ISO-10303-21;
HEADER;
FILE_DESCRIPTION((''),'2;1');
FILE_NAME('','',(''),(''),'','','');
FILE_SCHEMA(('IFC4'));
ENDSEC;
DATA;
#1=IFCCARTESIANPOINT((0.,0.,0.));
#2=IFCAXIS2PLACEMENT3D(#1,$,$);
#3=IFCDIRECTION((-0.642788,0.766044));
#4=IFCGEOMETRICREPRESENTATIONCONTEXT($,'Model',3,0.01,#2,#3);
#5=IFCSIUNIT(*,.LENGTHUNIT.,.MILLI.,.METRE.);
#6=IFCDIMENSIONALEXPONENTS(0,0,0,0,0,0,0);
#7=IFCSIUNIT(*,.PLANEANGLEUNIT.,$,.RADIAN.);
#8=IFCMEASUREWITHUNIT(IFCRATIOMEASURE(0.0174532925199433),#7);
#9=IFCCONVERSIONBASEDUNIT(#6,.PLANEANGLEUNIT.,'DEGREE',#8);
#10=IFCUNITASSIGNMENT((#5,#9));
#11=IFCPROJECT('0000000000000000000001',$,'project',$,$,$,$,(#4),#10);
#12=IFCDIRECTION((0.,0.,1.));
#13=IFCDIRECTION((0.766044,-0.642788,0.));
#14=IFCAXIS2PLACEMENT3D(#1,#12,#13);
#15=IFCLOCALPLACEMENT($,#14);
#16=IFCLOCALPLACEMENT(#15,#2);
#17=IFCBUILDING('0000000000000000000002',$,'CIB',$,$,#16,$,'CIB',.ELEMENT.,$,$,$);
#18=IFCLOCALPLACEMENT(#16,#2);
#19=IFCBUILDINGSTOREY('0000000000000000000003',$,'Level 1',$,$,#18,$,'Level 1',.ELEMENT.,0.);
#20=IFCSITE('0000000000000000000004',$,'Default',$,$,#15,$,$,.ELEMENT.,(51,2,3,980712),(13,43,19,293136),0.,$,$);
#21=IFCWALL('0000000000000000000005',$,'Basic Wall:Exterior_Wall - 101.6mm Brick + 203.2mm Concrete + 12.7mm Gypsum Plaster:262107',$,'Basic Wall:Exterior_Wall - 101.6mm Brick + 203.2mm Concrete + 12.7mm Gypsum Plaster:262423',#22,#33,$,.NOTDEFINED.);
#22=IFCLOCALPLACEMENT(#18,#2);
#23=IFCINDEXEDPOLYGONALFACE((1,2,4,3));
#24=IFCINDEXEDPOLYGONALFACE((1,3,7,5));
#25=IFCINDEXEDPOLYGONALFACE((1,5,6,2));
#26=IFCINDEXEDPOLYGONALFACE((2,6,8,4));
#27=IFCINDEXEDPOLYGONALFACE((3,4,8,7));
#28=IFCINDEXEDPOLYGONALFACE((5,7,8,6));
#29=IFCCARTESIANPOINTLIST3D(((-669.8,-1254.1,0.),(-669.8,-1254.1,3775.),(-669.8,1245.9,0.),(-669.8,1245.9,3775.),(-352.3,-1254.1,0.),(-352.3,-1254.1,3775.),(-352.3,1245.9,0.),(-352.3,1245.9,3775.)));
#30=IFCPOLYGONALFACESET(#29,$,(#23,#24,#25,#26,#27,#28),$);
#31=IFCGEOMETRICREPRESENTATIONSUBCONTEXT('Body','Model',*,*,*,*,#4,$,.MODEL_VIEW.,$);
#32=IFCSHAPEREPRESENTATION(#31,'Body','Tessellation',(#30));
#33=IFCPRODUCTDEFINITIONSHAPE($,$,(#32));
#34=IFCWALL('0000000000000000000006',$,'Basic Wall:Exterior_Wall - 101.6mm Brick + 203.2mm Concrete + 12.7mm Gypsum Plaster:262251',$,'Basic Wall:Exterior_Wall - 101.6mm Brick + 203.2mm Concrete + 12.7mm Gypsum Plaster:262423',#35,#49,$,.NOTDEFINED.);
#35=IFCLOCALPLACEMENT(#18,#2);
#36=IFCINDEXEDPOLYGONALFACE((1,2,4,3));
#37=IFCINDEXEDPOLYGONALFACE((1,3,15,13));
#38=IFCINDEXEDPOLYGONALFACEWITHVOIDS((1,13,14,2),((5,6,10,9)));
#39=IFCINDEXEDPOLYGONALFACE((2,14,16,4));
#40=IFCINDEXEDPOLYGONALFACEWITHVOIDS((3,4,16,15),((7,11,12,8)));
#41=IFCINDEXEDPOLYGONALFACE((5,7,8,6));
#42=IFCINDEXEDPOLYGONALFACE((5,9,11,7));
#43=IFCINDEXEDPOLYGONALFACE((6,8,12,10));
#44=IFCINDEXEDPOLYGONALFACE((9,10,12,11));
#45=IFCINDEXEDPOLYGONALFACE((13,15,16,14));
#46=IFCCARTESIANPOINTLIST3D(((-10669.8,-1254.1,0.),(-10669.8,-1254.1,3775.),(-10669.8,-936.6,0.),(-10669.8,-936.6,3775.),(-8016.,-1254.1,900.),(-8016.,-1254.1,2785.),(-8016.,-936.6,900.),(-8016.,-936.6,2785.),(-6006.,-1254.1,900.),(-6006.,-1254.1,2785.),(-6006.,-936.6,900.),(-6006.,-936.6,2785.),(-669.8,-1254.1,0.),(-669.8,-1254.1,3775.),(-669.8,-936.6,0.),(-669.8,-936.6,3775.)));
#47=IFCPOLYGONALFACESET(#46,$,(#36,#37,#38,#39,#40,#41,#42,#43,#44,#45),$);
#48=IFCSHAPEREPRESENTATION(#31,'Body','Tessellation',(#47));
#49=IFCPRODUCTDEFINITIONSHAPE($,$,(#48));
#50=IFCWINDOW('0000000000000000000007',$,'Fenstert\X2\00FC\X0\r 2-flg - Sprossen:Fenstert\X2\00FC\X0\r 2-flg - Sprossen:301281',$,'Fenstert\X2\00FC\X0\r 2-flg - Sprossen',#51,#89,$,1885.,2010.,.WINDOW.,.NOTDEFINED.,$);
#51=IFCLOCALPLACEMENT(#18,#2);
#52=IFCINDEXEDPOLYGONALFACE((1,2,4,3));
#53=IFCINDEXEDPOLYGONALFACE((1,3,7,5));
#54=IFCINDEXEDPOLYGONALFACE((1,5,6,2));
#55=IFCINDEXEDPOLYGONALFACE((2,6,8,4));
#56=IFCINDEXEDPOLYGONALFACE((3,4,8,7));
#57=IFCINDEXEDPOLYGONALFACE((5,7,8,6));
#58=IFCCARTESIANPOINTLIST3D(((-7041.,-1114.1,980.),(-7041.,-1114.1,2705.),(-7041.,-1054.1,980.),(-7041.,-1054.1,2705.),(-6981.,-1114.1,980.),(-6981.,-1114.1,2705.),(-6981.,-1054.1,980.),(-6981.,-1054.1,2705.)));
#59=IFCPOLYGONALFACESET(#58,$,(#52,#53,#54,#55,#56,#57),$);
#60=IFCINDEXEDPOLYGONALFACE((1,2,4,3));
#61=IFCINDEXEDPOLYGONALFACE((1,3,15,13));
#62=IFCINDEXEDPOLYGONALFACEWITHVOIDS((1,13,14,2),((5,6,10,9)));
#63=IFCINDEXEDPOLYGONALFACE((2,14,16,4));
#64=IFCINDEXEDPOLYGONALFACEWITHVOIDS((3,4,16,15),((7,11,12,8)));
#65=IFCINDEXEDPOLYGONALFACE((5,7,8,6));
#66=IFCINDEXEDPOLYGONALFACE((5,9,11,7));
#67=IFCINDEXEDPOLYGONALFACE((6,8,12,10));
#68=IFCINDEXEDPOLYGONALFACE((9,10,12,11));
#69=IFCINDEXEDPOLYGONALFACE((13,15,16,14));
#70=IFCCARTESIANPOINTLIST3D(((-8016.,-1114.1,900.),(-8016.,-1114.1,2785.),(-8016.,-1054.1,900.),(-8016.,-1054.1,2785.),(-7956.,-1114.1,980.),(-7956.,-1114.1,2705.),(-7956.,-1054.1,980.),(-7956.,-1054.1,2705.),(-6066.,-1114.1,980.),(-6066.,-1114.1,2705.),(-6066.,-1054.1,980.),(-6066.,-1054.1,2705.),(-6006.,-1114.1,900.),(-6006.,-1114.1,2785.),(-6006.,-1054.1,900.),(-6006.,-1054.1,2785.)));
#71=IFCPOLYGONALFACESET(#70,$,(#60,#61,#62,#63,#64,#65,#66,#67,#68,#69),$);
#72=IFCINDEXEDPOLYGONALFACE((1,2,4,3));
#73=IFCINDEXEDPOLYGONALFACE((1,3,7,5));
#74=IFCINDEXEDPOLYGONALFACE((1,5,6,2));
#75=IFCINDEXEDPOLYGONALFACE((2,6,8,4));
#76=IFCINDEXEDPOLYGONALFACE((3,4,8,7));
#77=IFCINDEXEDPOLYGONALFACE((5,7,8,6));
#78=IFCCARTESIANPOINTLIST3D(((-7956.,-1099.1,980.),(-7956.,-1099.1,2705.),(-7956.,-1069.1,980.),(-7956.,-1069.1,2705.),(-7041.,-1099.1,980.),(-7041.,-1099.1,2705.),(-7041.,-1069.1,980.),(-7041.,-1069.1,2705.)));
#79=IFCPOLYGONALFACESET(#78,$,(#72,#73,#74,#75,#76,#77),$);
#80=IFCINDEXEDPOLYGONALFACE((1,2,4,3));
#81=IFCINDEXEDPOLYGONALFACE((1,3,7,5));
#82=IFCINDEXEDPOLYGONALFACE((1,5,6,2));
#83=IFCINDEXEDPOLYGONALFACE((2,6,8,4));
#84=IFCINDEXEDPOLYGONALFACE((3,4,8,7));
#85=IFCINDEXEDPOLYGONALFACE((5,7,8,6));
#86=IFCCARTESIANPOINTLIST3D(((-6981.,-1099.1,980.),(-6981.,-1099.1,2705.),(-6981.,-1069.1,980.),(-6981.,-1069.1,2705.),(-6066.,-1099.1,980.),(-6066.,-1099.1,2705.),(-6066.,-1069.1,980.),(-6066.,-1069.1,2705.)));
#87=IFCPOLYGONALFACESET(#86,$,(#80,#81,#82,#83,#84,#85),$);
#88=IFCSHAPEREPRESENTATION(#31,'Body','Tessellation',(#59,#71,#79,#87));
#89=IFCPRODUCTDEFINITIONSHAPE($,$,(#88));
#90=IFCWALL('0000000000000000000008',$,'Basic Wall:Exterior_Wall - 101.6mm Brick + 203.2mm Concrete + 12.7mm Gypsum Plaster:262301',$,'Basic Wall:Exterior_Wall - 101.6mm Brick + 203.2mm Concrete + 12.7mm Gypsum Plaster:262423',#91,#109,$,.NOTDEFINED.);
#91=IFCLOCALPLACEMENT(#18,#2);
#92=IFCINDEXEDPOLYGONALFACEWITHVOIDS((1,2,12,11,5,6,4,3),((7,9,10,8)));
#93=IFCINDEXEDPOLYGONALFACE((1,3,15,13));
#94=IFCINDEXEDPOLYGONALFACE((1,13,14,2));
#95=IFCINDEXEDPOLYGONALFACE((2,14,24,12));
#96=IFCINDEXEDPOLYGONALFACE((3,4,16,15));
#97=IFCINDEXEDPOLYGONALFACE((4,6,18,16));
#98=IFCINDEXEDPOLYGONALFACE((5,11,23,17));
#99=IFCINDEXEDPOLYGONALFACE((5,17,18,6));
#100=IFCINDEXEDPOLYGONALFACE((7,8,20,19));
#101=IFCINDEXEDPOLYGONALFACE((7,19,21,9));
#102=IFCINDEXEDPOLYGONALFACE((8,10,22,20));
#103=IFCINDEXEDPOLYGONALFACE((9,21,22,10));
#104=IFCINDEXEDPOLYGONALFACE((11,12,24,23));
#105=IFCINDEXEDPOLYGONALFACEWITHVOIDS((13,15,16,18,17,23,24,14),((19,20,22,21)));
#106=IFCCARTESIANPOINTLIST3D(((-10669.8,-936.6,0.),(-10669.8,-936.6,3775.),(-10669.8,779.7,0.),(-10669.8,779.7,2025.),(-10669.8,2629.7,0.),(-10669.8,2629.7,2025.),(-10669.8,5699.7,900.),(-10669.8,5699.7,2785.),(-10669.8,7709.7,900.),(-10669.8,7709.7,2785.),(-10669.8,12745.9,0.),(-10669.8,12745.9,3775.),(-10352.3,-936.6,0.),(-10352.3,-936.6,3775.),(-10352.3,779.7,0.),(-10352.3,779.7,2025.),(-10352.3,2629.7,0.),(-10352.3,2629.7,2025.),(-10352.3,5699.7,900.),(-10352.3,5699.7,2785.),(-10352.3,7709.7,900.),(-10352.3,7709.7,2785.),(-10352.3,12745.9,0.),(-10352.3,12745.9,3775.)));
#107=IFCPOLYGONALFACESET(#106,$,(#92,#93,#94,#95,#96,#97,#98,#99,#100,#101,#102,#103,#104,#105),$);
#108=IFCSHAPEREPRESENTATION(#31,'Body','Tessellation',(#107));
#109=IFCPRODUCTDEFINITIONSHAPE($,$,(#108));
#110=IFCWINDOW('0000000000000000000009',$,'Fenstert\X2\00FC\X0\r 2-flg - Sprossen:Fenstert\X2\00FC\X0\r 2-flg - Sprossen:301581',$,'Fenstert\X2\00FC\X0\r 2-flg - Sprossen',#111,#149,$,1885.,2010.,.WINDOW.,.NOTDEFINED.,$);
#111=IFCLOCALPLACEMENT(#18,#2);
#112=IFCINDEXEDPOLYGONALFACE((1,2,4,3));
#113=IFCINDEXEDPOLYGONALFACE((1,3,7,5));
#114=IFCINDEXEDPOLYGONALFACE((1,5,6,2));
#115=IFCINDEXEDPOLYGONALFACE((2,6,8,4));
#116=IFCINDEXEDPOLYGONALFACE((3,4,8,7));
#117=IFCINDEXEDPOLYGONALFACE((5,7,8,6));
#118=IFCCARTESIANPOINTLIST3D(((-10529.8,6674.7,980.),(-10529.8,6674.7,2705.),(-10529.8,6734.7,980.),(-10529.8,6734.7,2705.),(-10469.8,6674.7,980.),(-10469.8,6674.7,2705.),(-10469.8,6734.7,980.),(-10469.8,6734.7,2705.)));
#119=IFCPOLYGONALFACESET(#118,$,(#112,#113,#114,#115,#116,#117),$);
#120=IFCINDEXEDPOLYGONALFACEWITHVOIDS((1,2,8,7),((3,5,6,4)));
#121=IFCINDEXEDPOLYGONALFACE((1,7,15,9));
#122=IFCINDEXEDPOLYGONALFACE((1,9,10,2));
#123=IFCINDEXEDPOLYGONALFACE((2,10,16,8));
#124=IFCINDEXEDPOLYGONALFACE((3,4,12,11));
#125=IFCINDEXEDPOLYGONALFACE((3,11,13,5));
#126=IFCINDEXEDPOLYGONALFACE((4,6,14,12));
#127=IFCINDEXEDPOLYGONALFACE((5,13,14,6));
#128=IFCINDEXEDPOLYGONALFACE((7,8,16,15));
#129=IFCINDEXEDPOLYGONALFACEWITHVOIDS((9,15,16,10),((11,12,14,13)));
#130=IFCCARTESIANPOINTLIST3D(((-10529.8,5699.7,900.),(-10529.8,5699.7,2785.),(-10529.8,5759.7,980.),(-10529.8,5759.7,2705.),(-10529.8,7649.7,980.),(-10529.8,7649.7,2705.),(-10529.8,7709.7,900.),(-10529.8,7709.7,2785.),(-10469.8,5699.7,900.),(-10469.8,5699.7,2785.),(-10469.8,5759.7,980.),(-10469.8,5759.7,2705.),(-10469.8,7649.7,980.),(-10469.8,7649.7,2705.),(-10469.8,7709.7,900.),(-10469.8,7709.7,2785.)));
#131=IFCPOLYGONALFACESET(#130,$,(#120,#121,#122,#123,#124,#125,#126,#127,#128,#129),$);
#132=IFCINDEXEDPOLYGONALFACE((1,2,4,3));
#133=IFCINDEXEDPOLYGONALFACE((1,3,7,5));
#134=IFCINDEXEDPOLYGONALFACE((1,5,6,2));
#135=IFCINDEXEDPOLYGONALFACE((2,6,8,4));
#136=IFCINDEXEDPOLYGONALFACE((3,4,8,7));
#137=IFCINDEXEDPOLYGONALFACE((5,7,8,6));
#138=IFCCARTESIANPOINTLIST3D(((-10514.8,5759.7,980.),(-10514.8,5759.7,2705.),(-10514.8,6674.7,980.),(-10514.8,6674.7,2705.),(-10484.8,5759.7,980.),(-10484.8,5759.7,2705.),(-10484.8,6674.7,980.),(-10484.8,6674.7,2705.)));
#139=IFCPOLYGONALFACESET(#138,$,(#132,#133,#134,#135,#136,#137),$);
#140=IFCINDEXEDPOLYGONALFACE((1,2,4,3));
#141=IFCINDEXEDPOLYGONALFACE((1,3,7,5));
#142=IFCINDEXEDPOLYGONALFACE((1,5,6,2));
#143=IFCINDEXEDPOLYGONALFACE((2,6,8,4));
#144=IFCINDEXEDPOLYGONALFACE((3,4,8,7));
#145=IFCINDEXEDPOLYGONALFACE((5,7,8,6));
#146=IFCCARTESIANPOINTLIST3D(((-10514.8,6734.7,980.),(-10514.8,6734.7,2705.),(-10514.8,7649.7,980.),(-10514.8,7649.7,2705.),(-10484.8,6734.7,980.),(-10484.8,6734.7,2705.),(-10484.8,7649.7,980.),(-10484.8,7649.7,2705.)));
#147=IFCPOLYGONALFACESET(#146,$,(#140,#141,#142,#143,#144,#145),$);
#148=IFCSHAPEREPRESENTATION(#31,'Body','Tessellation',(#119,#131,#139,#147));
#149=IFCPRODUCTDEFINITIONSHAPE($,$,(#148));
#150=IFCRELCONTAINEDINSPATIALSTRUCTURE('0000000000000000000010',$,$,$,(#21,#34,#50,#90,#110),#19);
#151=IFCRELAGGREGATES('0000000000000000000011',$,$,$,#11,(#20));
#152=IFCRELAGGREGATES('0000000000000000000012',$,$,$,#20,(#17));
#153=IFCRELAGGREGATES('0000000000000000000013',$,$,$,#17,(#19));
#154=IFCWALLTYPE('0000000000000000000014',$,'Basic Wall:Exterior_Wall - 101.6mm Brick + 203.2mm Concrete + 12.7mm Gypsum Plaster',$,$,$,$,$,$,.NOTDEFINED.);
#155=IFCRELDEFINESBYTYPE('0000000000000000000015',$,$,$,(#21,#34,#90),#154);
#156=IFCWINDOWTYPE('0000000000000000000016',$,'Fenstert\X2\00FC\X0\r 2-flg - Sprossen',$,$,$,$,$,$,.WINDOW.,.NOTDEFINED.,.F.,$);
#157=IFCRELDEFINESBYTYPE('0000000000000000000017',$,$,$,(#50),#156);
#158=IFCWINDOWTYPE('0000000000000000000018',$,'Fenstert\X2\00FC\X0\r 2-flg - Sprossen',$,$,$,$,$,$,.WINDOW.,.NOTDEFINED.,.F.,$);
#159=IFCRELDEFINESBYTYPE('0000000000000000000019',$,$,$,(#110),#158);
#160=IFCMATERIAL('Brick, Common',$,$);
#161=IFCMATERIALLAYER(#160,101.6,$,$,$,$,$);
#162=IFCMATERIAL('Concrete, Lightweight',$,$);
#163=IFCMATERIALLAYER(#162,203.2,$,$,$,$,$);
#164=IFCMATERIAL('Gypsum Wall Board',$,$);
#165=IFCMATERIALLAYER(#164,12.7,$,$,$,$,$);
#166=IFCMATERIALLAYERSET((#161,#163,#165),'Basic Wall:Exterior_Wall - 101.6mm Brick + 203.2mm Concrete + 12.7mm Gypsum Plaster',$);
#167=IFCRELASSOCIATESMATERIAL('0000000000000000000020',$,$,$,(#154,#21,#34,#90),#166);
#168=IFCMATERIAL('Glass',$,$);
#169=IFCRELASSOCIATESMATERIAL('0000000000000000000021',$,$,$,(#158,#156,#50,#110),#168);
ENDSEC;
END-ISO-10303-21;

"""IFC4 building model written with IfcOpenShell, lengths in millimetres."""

from ifc_helpers import new_model, entity, si_unit, converted_unit, direction, frame, frame_2d, origin, origin_2d_with_axis, place, context, subcontext, project, spatial, polyline, rectangle, outline, extrude, clip, bounded_halfspace, source, transform, mapped, material, layer, layer_set, layer_usage, type_object, type_shapes, element, fill, save


model = new_model("IFC4")

# Units and contexts
model_context = context("Model", 3, precision=0.01, world=origin(), true_north=direction((-0.642788, 0.766044)))
body_context = subcontext(model_context, "Body", "Model", "MODEL_VIEW")
ifc_project = project(units=[si_unit("LENGTHUNIT", "METRE", prefix="MILLI"), converted_unit("PLANEANGLEUNIT", "DEGREE", entity("IfcRatioMeasure", 0.0174532925199433), si_unit("PLANEANGLEUNIT", "RADIAN"), dimensions=[0, 0, 0, 0, 0, 0, 0])], contexts=[model_context])

# Site, building, storey
site_placement = place(None, frame((0.0, 0.0, 0.0), z_axis=(0.0, 0.0, 1.0), x_axis=(0.766044, -0.642788, 0.0)))
site = spatial("IfcSite", under=ifc_project, at=site_placement, Name="Default", CompositionType="ELEMENT", RefLatitude=(51, 2, 3, 980712), RefLongitude=(13, 43, 19, 293136), RefElevation=0.0)
building_placement = place(site_placement, origin())
building = spatial("IfcBuilding", under=site, at=building_placement, Name="CIB", LongName="CIB", CompositionType="ELEMENT")
storey_placement = place(building_placement, origin())
storey = spatial("IfcBuildingStorey", under=building, at=storey_placement, Name="Level 1", LongName="Level 1", CompositionType="ELEMENT", Elevation=0.0)

# Shared definitions
ifc_material_1 = material(Name="Brick, Common")
ifc_layer_1 = layer(ifc_material_1, 101.6)
ifc_material_2 = material(Name="Concrete, Lightweight")
ifc_layer_2 = layer(ifc_material_2, 203.2)
ifc_material_3 = material(Name="Gypsum Wall Board")
ifc_layer_3 = layer(ifc_material_3, 12.7)
ifc_layer_set_1 = layer_set([ifc_layer_1, ifc_layer_2, ifc_layer_3], Name="Basic Wall:Exterior_Wall - 101.6mm Brick + 203.2mm Concrete + 12.7mm Gypsum Plaster")
wall_type_1 = type_object("IfcWallType", Name="Basic Wall:Exterior_Wall - 101.6mm Brick + 203.2mm Concrete + 12.7mm Gypsum Plaster", PredefinedType="NOTDEFINED", material=ifc_layer_set_1)
ifc_material_4 = material(Name="Glass")
window_type_1 = type_object("IfcWindowType", Name="Fenstertür 2-flg - Sprossen", ParameterTakesPrecedence=False, PartitioningType="NOTDEFINED", PredefinedType="WINDOW", material=ifc_material_4)
shared_shape_1 = source(origin(), body_context, "Body", "SweptSolid", [
    extrude(rectangle(XDim=60.0, YDim=60.0, at=origin_2d_with_axis()), frame((1005.0, 147.5, 80.0), z_axis=(0.0, 0.0, 1.0), x_axis=(0.0, 1.0, 0.0)), (0.0, 0.0, 1.0), 1725.0),
    extrude(outline(polyline([(-1005.0, -942.5), (1005.0, -942.5), (1005.0, 942.5), (-1005.0, 942.5), (-1005.0, -942.5)]), holes=[polyline([(-945.0, -862.5), (-945.0, 862.5), (945.0, 862.5), (945.0, -862.5), (-945.0, -862.5)])]), frame((1005.0, 117.5, 942.5), z_axis=(0.0, 1.0, 0.0), x_axis=(1.0, 0.0, 0.0)), (0.0, 0.0, 1.0), 60.0),
    extrude(rectangle(XDim=30.0, YDim=915.0, at=frame_2d((0.0, 0.0), x_axis=(1.0, 0.0))), frame((517.5, 147.5, 80.0), z_axis=(0.0, 0.0, 1.0), x_axis=(0.0, -1.0, 0.0)), (0.0, 0.0, 1.0), 1725.0),
    extrude(rectangle(XDim=30.0, YDim=915.0, at=frame_2d((0.0, 0.0), x_axis=(1.0, 0.0))), frame((1492.5, 147.5, 80.0), z_axis=(0.0, 0.0, 1.0), x_axis=(0.0, -1.0, 0.0)), (0.0, 0.0, 1.0), 1725.0),
])
type_shapes(window_type_1, [shared_shape_1])

# Wall
ifc_layer_usage_1 = layer_usage(ifc_layer_set_1, "AXIS2", "NEGATIVE", 158.8)
wall_1_placement = place(storey_placement, frame((-511.0, 1245.9, 0.0), z_axis=(0.0, 0.0, 1.0), x_axis=(0.0, -1.0, 0.0)))
element("IfcWall", 1, at=wall_1_placement, inside=storey, type_object=wall_type_1, material=ifc_layer_usage_1, Name="Basic Wall:Exterior_Wall - 101.6mm Brick + 203.2mm Concrete + 12.7mm Gypsum Plaster:262107", ObjectType="Basic Wall:Exterior_Wall - 101.6mm Brick + 203.2mm Concrete + 12.7mm Gypsum Plaster:262423", PredefinedType="NOTDEFINED", context=body_context, shape_type="Clipping", body=[
    clip(extrude(rectangle(XDim=2500.0, YDim=317.5, at=frame_2d((1250.0, 0.0), x_axis=(-1.0, 0.0))), origin(), (0.0, 0.0, 1.0), 3775.0), bounded_halfspace(frame((0.0, -158.8, 3775.0), z_axis=(0.0, 0.0, -1.0), x_axis=(0.0, 1.0, 0.0)), True, frame((0.0, -158.8, 3775.0)), polyline([(0.0, 0.0), (2182.5, 0.0), (2500.0, 0.0), (2500.0, 317.5), (0.0, 317.5), (0.0, 0.0)]))),
])

# Wall, opening, window
ifc_layer_usage_2 = layer_usage(ifc_layer_set_1, "AXIS2", "NEGATIVE", 158.8)
wall_2_placement = place(storey_placement, frame((-669.8, -1095.3, 0.0), z_axis=(0.0, 0.0, 1.0), x_axis=(-1.0, 0.0, 0.0)))
wall_2 = element("IfcWall", 2, at=wall_2_placement, inside=storey, type_object=wall_type_1, material=ifc_layer_usage_2, Name="Basic Wall:Exterior_Wall - 101.6mm Brick + 203.2mm Concrete + 12.7mm Gypsum Plaster:262251", ObjectType="Basic Wall:Exterior_Wall - 101.6mm Brick + 203.2mm Concrete + 12.7mm Gypsum Plaster:262423", PredefinedType="NOTDEFINED", context=body_context, shape_type="Clipping", body=[
    clip(extrude(rectangle(XDim=10000.0, YDim=317.5, at=frame_2d((5000.0, 0.0), x_axis=(-1.0, 0.0))), origin(), (0.0, 0.0, 1.0), 3775.0), bounded_halfspace(frame((0.0, -158.8, 3775.0), z_axis=(0.0, 0.0, -1.0), x_axis=(-1.0, 0.0, 0.0)), True, frame((0.0, -158.8, 3775.0)), polyline([(0.0, 0.0), (9682.5, 0.0), (10000.0, 0.0), (10000.0, 317.5), (0.0, 317.5), (0.0, 0.0)]))),
])
opening_1_placement = place(wall_2_placement, frame((7346.2, 158.7, 900.0)))
opening_1 = element("IfcOpeningElement", 3, at=opening_1_placement, cuts=wall_2, ObjectType="Opening", PredefinedType="OPENING", context=body_context, shape_type="SweptSolid", body=[
    extrude(rectangle(XDim=1885.0, YDim=2010.0, at=frame_2d((942.5, 1005.0), x_axis=(1.0, 0.0))), frame((0.0, 0.0, 0.0), z_axis=(0.0, -1.0, 0.0), x_axis=(0.0, 0.0, 1.0)), (0.0, 0.0, 1.0), 317.5),
])
window_type_2 = type_object("IfcWindowType", Name="Fenstertür 2-flg - Sprossen", ParameterTakesPrecedence=False, PartitioningType="NOTDEFINED", PredefinedType="WINDOW", material=ifc_material_4)
shared_shape_2 = source(origin(), body_context, "Body", "SweptSolid", [
    extrude(rectangle(XDim=60.0, YDim=60.0, at=frame_2d((0.0, 0.0), x_axis=(1.0, 0.0))), frame((1005.0, 147.5, 80.0)), (0.0, 0.0, 1.0), 1725.0),
    extrude(outline(polyline([(-1005.0, -942.5), (1005.0, -942.5), (1005.0, 942.5), (-1005.0, 942.5), (-1005.0, -942.5)]), holes=[polyline([(-945.0, -862.5), (-945.0, 862.5), (945.0, 862.5), (945.0, -862.5), (-945.0, -862.5)])]), frame((1005.0, 177.5, 942.5), z_axis=(0.0, -1.0, 0.0), x_axis=(-1.0, 0.0, 0.0)), (0.0, 0.0, 1.0), 60.0),
    extrude(rectangle(XDim=915.0, YDim=30.0, at=frame_2d((0.0, 0.0), x_axis=(1.0, 0.0))), frame((1492.5, 147.5, 80.0), z_axis=(0.0, 0.0, 1.0), x_axis=(-1.0, 0.0, 0.0)), (0.0, 0.0, 1.0), 1725.0),
    extrude(rectangle(XDim=915.0, YDim=30.0, at=frame_2d((0.0, 0.0), x_axis=(1.0, 0.0))), frame((517.5, 147.5, 80.0), z_axis=(0.0, 0.0, 1.0), x_axis=(-1.0, 0.0, 0.0)), (0.0, 0.0, 1.0), 1725.0),
])
type_shapes(window_type_2, [shared_shape_2])
window_1_placement = place(opening_1_placement, frame((-2010.0, -317.5, 0.0)))
window_1 = element("IfcWindow", 4, at=window_1_placement, inside=storey, type_object=window_type_2, material=ifc_material_4, Name="Fenstertür 2-flg - Sprossen:Fenstertür 2-flg - Sprossen:301281", ObjectType="Fenstertür 2-flg - Sprossen", OverallHeight=1885.0, OverallWidth=2010.0, PartitioningType="NOTDEFINED", PredefinedType="WINDOW", context=body_context, shape_type="MappedRepresentation", body=[
    mapped(shared_shape_2, transform((0.0, 0.0, 0.0), scale=1.0)),
])
fill(opening_1, window_1)

# Wall, openings, window
ifc_layer_usage_3 = layer_usage(ifc_layer_set_1, "AXIS2", "NEGATIVE", 158.8)
wall_3_placement = place(storey_placement, frame((-10511.0, -936.6, 0.0), z_axis=(0.0, 0.0, 1.0), x_axis=(0.0, 1.0, 0.0)))
wall_3 = element("IfcWall", 5, at=wall_3_placement, inside=storey, type_object=wall_type_1, material=ifc_layer_usage_3, Name="Basic Wall:Exterior_Wall - 101.6mm Brick + 203.2mm Concrete + 12.7mm Gypsum Plaster:262301", ObjectType="Basic Wall:Exterior_Wall - 101.6mm Brick + 203.2mm Concrete + 12.7mm Gypsum Plaster:262423", PredefinedType="NOTDEFINED", context=body_context, shape_type="Clipping", body=[
    clip(extrude(rectangle(XDim=13682.5, YDim=317.5, at=frame_2d((6841.2, 0.0), x_axis=(-1.0, 0.0))), origin(), (0.0, 0.0, 1.0), 3775.0), bounded_halfspace(frame((0.0, -158.7, 3775.0), z_axis=(0.0, 0.0, -1.0), x_axis=(0.0, -1.0, 0.0)), True, frame((0.0, -158.7, 3775.0)), polyline([(0.0, 0.0), (13682.5, 0.0), (13682.5, 317.5), (0.0, 317.5), (0.0, 0.0)]))),
])
opening_2_placement = place(wall_3_placement, frame((3566.2, 158.7, 0.0)))
element("IfcOpeningElement", 6, at=opening_2_placement, cuts=wall_3, ObjectType="Opening", PredefinedType="OPENING", context=body_context, shape_type="SweptSolid", body=[
    extrude(rectangle(XDim=2025.0, YDim=1850.0, at=frame_2d((1012.5, 925.0), x_axis=(1.0, 0.0))), frame((0.0, 0.0, 0.0), z_axis=(0.0, -1.0, 0.0), x_axis=(0.0, 0.0, 1.0)), (0.0, 0.0, 1.0), 317.5),
])
opening_3_placement = place(wall_3_placement, frame((8646.2, 158.7, 900.0)))
opening_3 = element("IfcOpeningElement", 7, at=opening_3_placement, cuts=wall_3, ObjectType="Opening", PredefinedType="OPENING", context=body_context, shape_type="SweptSolid", body=[
    extrude(rectangle(XDim=1885.0, YDim=2010.0, at=frame_2d((942.5, 1005.0), x_axis=(1.0, 0.0))), frame((0.0, 0.0, 0.0), z_axis=(0.0, -1.0, 0.0), x_axis=(0.0, 0.0, 1.0)), (0.0, 0.0, 1.0), 317.5),
])
window_2_placement = place(opening_3_placement, frame((-2010.0, -317.5, 0.0)))
window_2 = element("IfcWindow", 8, at=window_2_placement, inside=storey, type_object=window_type_1, material=ifc_material_4, Name="Fenstertür 2-flg - Sprossen:Fenstertür 2-flg - Sprossen:301581", ObjectType="Fenstertür 2-flg - Sprossen", OverallHeight=1885.0, OverallWidth=2010.0, PartitioningType="NOTDEFINED", PredefinedType="WINDOW", context=body_context, shape_type="MappedRepresentation", body=[
    mapped(shared_shape_1, transform((0.0, 0.0, 0.0), scale=1.0)),
])
fill(opening_3, window_2)

save(model, "model.ifc")
